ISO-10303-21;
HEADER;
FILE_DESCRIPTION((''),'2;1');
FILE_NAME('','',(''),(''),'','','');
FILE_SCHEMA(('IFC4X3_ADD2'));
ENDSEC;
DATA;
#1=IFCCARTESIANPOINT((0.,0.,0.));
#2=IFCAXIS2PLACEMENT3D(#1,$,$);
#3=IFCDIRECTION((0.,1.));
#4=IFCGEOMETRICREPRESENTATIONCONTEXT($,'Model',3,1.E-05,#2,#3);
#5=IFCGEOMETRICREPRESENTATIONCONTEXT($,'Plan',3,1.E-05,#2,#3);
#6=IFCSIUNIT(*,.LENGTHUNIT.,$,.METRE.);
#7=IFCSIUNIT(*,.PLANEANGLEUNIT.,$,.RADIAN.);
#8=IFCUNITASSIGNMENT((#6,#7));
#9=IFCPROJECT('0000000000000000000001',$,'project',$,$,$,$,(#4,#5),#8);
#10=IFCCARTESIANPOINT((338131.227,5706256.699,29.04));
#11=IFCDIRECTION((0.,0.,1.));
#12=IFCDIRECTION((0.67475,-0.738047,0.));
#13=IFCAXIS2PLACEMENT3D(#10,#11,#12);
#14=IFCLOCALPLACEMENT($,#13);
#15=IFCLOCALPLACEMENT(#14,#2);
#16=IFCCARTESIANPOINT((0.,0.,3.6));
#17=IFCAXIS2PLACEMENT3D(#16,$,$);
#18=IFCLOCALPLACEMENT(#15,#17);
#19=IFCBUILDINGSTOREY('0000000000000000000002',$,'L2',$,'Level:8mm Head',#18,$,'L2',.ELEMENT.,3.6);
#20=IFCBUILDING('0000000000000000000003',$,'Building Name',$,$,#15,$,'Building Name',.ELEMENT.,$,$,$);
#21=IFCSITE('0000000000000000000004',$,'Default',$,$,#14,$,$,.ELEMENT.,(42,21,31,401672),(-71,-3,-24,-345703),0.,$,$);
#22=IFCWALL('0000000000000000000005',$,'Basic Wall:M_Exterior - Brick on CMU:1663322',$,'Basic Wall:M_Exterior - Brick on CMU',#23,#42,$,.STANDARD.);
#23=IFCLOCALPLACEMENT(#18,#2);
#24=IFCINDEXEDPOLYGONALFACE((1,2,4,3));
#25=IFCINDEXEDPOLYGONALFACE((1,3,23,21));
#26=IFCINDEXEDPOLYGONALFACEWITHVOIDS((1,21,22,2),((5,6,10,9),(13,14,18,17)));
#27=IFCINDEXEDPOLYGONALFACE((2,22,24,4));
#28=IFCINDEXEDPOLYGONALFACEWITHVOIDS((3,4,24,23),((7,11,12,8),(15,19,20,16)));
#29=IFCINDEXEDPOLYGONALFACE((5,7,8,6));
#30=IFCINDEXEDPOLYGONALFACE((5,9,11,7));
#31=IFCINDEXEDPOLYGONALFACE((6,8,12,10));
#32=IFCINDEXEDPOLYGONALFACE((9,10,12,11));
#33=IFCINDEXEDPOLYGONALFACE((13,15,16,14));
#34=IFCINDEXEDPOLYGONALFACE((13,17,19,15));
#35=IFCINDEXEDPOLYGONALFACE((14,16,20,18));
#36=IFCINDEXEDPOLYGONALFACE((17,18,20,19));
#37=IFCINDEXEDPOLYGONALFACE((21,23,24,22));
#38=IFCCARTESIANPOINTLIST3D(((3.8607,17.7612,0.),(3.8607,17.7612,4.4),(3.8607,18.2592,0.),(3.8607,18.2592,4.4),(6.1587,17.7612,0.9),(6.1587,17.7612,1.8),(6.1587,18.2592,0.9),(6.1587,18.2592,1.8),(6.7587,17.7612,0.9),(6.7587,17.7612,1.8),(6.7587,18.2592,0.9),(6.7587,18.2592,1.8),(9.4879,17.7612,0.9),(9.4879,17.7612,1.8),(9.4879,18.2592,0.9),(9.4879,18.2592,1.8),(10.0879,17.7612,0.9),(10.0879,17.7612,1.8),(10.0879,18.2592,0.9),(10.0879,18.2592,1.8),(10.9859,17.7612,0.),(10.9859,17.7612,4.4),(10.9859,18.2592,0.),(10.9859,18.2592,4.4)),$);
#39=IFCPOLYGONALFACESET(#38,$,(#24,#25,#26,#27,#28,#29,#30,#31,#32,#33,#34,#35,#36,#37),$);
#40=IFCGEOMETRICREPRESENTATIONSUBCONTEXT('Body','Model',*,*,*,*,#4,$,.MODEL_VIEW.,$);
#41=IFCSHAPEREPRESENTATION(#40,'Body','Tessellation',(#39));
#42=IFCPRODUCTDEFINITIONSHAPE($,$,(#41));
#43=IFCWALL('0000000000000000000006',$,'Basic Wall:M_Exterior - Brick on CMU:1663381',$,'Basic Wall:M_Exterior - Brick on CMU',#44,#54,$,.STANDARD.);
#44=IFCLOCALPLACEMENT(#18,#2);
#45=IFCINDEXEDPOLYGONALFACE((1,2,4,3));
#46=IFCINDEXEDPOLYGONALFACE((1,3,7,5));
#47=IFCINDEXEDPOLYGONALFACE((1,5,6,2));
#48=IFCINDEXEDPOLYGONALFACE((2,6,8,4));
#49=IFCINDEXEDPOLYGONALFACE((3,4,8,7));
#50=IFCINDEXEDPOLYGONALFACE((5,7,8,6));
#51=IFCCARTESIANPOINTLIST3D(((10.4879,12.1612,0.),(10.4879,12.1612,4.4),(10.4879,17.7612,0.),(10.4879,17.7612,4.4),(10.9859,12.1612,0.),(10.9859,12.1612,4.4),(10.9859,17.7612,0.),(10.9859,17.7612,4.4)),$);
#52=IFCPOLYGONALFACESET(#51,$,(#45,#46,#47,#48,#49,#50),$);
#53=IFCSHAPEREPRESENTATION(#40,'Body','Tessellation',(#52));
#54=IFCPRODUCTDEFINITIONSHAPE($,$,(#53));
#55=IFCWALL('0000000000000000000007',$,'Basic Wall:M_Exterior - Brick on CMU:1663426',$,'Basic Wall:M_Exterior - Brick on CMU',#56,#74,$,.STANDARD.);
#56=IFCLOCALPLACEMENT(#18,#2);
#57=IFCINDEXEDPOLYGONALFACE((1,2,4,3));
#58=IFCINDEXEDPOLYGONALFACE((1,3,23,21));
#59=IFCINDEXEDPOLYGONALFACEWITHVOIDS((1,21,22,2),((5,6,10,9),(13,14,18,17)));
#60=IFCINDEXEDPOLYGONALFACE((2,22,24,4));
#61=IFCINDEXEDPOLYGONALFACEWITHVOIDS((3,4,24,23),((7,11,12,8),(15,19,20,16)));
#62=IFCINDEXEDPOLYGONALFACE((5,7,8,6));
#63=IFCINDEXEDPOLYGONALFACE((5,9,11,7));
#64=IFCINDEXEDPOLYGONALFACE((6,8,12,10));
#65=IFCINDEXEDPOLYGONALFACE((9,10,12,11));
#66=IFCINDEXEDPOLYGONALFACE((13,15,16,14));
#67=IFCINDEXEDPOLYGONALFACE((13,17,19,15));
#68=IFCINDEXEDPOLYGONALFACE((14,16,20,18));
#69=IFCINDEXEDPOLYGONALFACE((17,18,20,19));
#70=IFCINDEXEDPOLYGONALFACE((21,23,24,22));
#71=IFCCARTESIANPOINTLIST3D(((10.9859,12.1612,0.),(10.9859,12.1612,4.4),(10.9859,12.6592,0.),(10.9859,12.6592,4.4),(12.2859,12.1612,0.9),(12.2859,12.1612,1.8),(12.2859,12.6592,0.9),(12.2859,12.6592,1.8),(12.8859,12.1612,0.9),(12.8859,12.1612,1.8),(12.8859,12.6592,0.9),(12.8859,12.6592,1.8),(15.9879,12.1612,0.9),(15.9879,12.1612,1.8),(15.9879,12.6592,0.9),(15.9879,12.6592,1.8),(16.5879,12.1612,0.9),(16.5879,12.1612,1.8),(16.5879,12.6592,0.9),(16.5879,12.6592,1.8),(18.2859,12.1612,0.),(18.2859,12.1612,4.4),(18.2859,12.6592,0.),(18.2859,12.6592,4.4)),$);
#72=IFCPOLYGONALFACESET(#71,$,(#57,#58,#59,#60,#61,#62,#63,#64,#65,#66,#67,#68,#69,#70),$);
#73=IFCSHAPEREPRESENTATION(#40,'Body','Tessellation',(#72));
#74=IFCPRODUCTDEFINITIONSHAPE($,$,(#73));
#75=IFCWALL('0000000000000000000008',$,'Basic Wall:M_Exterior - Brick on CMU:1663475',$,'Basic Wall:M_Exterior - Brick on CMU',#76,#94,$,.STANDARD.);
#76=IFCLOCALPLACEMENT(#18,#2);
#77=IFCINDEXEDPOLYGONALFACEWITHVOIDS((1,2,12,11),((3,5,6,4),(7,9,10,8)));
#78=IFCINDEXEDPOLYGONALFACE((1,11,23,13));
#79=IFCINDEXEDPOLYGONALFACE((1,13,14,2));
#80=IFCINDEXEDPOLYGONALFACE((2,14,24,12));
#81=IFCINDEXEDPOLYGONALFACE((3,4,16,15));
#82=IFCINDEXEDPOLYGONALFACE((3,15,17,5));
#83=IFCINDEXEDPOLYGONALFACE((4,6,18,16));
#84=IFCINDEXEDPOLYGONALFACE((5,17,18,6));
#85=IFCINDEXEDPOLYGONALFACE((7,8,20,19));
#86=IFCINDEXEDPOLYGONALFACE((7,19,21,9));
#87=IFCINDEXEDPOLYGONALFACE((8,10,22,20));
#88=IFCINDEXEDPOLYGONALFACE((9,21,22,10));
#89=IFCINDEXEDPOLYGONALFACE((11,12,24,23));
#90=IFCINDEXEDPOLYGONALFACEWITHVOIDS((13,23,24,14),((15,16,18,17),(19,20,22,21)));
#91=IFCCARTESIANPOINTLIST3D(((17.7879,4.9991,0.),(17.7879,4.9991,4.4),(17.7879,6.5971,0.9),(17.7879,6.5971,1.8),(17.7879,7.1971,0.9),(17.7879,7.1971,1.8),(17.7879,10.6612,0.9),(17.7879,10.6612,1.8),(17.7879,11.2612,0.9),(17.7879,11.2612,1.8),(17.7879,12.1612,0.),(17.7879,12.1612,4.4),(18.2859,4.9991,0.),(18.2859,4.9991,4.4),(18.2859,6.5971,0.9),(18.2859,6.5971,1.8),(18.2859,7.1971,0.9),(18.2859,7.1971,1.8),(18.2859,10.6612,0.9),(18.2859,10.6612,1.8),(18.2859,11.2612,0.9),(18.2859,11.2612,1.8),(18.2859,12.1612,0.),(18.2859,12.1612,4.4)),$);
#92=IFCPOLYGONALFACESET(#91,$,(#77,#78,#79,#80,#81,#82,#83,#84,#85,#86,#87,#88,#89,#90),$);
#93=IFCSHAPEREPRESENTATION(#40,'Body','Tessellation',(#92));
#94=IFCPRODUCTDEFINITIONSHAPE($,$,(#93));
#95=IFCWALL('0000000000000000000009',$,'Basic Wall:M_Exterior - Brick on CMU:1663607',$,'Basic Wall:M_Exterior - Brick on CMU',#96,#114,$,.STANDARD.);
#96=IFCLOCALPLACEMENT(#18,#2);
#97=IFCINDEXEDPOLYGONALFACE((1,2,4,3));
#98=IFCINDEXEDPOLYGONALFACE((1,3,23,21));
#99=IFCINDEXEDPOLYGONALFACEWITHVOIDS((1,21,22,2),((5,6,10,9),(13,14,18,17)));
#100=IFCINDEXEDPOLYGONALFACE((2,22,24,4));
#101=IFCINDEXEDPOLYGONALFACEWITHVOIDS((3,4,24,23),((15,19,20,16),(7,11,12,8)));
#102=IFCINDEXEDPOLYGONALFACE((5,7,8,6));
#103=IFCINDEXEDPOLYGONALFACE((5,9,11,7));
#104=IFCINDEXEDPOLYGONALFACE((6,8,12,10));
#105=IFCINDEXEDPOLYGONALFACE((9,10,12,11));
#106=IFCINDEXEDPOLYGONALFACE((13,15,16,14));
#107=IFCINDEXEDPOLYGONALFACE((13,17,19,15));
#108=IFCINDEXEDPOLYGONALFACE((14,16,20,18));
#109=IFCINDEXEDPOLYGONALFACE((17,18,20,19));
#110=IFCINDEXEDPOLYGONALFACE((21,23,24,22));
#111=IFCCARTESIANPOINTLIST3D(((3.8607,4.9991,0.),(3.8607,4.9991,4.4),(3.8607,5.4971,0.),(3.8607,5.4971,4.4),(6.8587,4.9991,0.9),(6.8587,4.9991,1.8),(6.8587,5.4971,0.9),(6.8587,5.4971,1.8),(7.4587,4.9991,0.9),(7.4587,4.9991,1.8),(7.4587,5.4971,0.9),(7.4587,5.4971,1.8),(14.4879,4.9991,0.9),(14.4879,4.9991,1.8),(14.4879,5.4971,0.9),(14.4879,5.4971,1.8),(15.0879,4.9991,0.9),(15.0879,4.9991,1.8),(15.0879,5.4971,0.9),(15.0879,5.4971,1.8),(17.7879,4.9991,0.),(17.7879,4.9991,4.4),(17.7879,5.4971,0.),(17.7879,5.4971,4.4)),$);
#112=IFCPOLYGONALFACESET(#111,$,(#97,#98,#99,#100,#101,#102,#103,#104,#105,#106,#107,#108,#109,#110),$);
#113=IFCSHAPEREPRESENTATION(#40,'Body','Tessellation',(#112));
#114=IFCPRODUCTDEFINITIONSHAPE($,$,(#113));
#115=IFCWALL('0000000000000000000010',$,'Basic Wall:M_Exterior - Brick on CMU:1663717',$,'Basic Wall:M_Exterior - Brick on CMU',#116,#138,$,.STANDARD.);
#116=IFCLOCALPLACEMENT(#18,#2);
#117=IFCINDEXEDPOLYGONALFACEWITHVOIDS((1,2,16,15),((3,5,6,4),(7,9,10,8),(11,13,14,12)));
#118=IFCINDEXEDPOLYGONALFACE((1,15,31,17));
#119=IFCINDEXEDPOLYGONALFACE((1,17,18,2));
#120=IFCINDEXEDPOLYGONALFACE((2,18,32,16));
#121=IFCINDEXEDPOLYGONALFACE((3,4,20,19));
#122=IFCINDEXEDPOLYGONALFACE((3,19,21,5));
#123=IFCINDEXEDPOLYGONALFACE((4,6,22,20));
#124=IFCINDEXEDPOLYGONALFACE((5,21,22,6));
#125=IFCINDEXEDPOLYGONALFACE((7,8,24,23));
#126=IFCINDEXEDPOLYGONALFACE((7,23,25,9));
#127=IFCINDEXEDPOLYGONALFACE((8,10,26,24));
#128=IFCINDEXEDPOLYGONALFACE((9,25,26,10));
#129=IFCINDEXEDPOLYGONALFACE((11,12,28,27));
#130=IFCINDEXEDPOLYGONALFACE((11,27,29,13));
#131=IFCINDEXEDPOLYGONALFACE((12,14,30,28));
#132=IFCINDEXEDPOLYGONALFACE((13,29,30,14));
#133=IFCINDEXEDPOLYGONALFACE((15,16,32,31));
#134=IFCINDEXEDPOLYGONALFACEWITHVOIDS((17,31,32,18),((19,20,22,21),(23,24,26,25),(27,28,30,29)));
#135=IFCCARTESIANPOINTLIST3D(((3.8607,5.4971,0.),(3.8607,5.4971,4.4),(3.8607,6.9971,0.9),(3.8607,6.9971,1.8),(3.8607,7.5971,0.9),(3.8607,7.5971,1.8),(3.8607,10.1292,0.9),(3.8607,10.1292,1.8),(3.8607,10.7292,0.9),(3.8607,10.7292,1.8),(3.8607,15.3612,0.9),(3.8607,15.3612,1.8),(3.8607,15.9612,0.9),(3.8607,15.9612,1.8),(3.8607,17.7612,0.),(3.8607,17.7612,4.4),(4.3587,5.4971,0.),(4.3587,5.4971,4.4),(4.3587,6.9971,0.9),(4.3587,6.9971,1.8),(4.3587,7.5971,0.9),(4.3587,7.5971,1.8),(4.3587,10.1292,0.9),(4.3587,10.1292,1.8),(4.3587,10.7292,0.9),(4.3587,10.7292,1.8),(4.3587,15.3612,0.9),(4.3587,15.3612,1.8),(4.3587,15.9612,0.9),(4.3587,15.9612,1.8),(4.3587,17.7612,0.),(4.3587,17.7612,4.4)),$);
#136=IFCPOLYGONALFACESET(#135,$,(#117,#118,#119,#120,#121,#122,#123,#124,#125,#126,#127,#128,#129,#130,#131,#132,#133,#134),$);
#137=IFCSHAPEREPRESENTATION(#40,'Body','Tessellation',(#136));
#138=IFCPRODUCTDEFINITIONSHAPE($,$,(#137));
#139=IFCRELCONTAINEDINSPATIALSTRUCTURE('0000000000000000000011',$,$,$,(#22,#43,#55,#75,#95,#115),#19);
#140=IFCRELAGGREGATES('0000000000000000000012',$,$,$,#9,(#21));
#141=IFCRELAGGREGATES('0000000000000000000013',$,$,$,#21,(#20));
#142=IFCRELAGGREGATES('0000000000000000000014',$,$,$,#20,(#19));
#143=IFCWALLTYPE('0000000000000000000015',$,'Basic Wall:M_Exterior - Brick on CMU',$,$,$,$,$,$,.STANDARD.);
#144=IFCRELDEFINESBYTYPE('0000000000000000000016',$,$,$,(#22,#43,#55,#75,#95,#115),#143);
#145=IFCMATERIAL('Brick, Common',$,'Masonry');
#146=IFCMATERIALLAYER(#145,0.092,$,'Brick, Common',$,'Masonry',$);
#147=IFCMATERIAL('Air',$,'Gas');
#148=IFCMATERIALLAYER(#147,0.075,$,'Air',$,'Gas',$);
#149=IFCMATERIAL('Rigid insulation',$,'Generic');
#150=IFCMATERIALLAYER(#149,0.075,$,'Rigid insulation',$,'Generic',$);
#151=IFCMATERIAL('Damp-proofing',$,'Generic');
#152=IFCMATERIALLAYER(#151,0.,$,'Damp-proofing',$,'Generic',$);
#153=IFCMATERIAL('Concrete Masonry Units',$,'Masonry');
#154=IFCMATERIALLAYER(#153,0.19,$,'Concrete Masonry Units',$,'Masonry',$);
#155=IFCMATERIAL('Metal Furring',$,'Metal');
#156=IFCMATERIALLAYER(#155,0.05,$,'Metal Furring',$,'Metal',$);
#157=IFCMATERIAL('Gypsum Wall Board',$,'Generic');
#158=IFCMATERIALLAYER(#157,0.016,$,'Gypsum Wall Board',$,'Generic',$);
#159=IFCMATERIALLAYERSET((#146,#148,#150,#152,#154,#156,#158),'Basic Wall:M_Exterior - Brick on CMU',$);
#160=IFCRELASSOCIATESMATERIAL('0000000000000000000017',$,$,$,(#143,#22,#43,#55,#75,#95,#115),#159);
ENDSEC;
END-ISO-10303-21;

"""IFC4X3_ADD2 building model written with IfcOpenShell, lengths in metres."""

from ifc_helpers import new_model, si_unit, direction, frame, frame_2d, origin, place, context, subcontext, project, spatial, rectangle, extrude, material, layer, layer_set, type_object, element, save


model = new_model("IFC4X3_ADD2")

# Units and contexts
model_context = context("Model", 3, precision=1e-05, world=origin(), true_north=direction((0.0, 1.0)))
plan_context = context("Plan", 3, precision=1e-05, world=origin(), true_north=direction((0.0, 1.0)))
body_context = subcontext(model_context, "Body", "Model", "MODEL_VIEW")
ifc_project = project(units=[si_unit("LENGTHUNIT", "METRE"), si_unit("PLANEANGLEUNIT", "RADIAN")], contexts=[model_context, plan_context])

# Site, building, storey
site_placement = place(None, frame((338131.227, 5706256.699, 29.04), z_axis=(0.0, 0.0, 1.0), x_axis=(0.67475, -0.738047, 0.0)))
site = spatial("IfcSite", under=ifc_project, at=site_placement, Name="Default", CompositionType="ELEMENT", RefLatitude=(42, 21, 31, 401672), RefLongitude=(-71, -3, -24, -345703), RefElevation=0.0)
building_placement = place(site_placement, origin())
building = spatial("IfcBuilding", under=site, at=building_placement, Name="Building Name", LongName="Building Name", CompositionType="ELEMENT")
storey_placement = place(building_placement, frame((0.0, 0.0, 3.6)))
storey = spatial("IfcBuildingStorey", under=building, at=storey_placement, Name="L2", ObjectType="Level:8mm Head", LongName="L2", CompositionType="ELEMENT", Elevation=3.6)

# Wall, openings
ifc_material_1 = material(Name="Brick, Common", Category="Masonry")
ifc_layer_1 = layer(ifc_material_1, 0.092, Name="Brick, Common", Category="Masonry")
ifc_material_2 = material(Name="Air", Category="Gas")
ifc_layer_2 = layer(ifc_material_2, 0.075, Name="Air", Category="Gas")
ifc_material_3 = material(Name="Rigid insulation", Category="Generic")
ifc_layer_3 = layer(ifc_material_3, 0.075, Name="Rigid insulation", Category="Generic")
ifc_material_4 = material(Name="Damp-proofing", Category="Generic")
ifc_layer_4 = layer(ifc_material_4, 0.0, Name="Damp-proofing", Category="Generic")
ifc_material_5 = material(Name="Concrete Masonry Units", Category="Masonry")
ifc_layer_5 = layer(ifc_material_5, 0.19, Name="Concrete Masonry Units", Category="Masonry")
ifc_material_6 = material(Name="Metal Furring", Category="Metal")
ifc_layer_6 = layer(ifc_material_6, 0.05, Name="Metal Furring", Category="Metal")
ifc_material_7 = material(Name="Gypsum Wall Board", Category="Generic")
ifc_layer_7 = layer(ifc_material_7, 0.016, Name="Gypsum Wall Board", Category="Generic")
ifc_layer_set = layer_set([ifc_layer_1, ifc_layer_2, ifc_layer_3, ifc_layer_4, ifc_layer_5, ifc_layer_6, ifc_layer_7], Name="Basic Wall:M_Exterior - Brick on CMU")
wall_type = type_object("IfcWallType", Name="Basic Wall:M_Exterior - Brick on CMU", PredefinedType="STANDARD", material=ifc_layer_set)
wall_1_placement = place(storey_placement, frame((3.8607, 18.0102, 0.0)))
wall_1 = element("IfcWall", 1, at=wall_1_placement, inside=storey, type_object=wall_type, material=ifc_layer_set, Name="Basic Wall:M_Exterior - Brick on CMU:1663322", ObjectType="Basic Wall:M_Exterior - Brick on CMU", PredefinedType="STANDARD", context=body_context, shape_type="SweptSolid", body=[
    extrude(rectangle(XDim=7.1251, YDim=0.498, at=frame_2d((3.5626, 0.0), x_axis=(-1.0, 0.0))), origin(), (0.0, 0.0, 1.0), 4.4),
])
opening_1_placement = place(wall_1_placement, frame((-3.8607, -18.0102, 0.9)))
element("IfcOpeningElement", 2, at=opening_1_placement, cuts=wall_1, PredefinedType="OPENING", context=body_context, shape_type="SweptSolid", body=[
    extrude(rectangle(XDim=0.9, YDim=0.6, at=frame_2d((0.0, 0.0), x_axis=(1.0, 0.0))), frame((9.7879, 16.2372, 0.45), z_axis=(0.0, 1.0, 0.0), x_axis=(0.0, 0.0, -1.0)), (0.0, 0.0, 1.0), 3.048),
])
opening_2_placement = place(wall_1_placement, frame((-3.8607, -18.0102, 0.9)))
element("IfcOpeningElement", 3, at=opening_2_placement, cuts=wall_1, PredefinedType="OPENING", context=body_context, shape_type="SweptSolid", body=[
    extrude(rectangle(XDim=0.9, YDim=0.6, at=frame_2d((0.0, 0.0), x_axis=(1.0, 0.0))), frame((6.4587, 16.2372, 0.45), z_axis=(0.0, 1.0, 0.0), x_axis=(0.0, 0.0, -1.0)), (0.0, 0.0, 1.0), 3.048),
])

# Wall
wall_2_placement = place(storey_placement, frame((10.7369, 17.7612, 0.0), z_axis=(0.0, 0.0, 1.0), x_axis=(0.0, -1.0, 0.0)))
element("IfcWall", 4, at=wall_2_placement, inside=storey, type_object=wall_type, material=ifc_layer_set, Name="Basic Wall:M_Exterior - Brick on CMU:1663381", ObjectType="Basic Wall:M_Exterior - Brick on CMU", PredefinedType="STANDARD", context=body_context, shape_type="SweptSolid", body=[
    extrude(rectangle(XDim=5.6, YDim=0.498, at=frame_2d((2.8, 0.0), x_axis=(-1.0, 0.0))), origin(), (0.0, 0.0, 1.0), 4.4),
])

# Walls, openings
wall_3_placement = place(storey_placement, frame((10.9859, 12.4102, 0.0)))
wall_3 = element("IfcWall", 5, at=wall_3_placement, inside=storey, type_object=wall_type, material=ifc_layer_set, Name="Basic Wall:M_Exterior - Brick on CMU:1663426", ObjectType="Basic Wall:M_Exterior - Brick on CMU", PredefinedType="STANDARD", context=body_context, shape_type="SweptSolid", body=[
    extrude(rectangle(XDim=7.3, YDim=0.498, at=frame_2d((3.65, 0.0), x_axis=(-1.0, 0.0))), origin(), (0.0, 0.0, 1.0), 4.4),
])
opening_3_placement = place(wall_3_placement, frame((-10.9859, -12.4102, 0.9)))
element("IfcOpeningElement", 6, at=opening_3_placement, cuts=wall_3, PredefinedType="OPENING", context=body_context, shape_type="SweptSolid", body=[
    extrude(rectangle(XDim=0.9, YDim=0.6, at=frame_2d((0.0, 0.0), x_axis=(1.0, 0.0))), frame((16.2879, 10.6372, 0.45), z_axis=(0.0, 1.0, 0.0), x_axis=(0.0, 0.0, -1.0)), (0.0, 0.0, 1.0), 3.048),
])
opening_4_placement = place(wall_3_placement, frame((-10.9859, -12.4102, 0.9)))
element("IfcOpeningElement", 7, at=opening_4_placement, cuts=wall_3, PredefinedType="OPENING", context=body_context, shape_type="SweptSolid", body=[
    extrude(rectangle(XDim=0.9, YDim=0.6, at=frame_2d((0.0, 0.0), x_axis=(1.0, 0.0))), frame((12.5859, 10.6372, 0.45), z_axis=(0.0, 1.0, 0.0), x_axis=(0.0, 0.0, -1.0)), (0.0, 0.0, 1.0), 3.048),
])
wall_4_placement = place(storey_placement, frame((18.0369, 12.1612, 0.0), z_axis=(0.0, 0.0, 1.0), x_axis=(0.0, -1.0, 0.0)))
wall_4 = element("IfcWall", 8, at=wall_4_placement, inside=storey, type_object=wall_type, material=ifc_layer_set, Name="Basic Wall:M_Exterior - Brick on CMU:1663475", ObjectType="Basic Wall:M_Exterior - Brick on CMU", PredefinedType="STANDARD", context=body_context, shape_type="SweptSolid", body=[
    extrude(rectangle(XDim=7.1621, YDim=0.498, at=frame_2d((3.581, 0.0), x_axis=(-1.0, 0.0))), origin(), (0.0, 0.0, 1.0), 4.4),
])
opening_5_placement = place(wall_4_placement, frame((12.1612, -18.0369, 0.9)))
element("IfcOpeningElement", 9, at=opening_5_placement, cuts=wall_4, PredefinedType="OPENING", context=body_context, shape_type="SweptSolid", body=[
    extrude(rectangle(XDim=0.9, YDim=0.6, at=frame_2d((0.0, 0.0), x_axis=(1.0, 0.0))), frame((-6.8971, 16.2639, 0.45), z_axis=(0.0, 1.0, 0.0), x_axis=(0.0, 0.0, -1.0)), (0.0, 0.0, 1.0), 3.048),
])
opening_6_placement = place(wall_4_placement, frame((12.1612, -18.0369, 0.9)))
element("IfcOpeningElement", 10, at=opening_6_placement, cuts=wall_4, PredefinedType="OPENING", context=body_context, shape_type="SweptSolid", body=[
    extrude(rectangle(XDim=0.9, YDim=0.6, at=frame_2d((0.0, 0.0), x_axis=(1.0, 0.0))), frame((-10.9612, 16.2639, 0.45), z_axis=(0.0, 1.0, 0.0), x_axis=(0.0, 0.0, -1.0)), (0.0, 0.0, 1.0), 3.048),
])
wall_5_placement = place(storey_placement, frame((17.7879, 5.2481, 0.0), z_axis=(0.0, 0.0, 1.0), x_axis=(-1.0, 0.0, 0.0)))
wall_5 = element("IfcWall", 11, at=wall_5_placement, inside=storey, type_object=wall_type, material=ifc_layer_set, Name="Basic Wall:M_Exterior - Brick on CMU:1663607", ObjectType="Basic Wall:M_Exterior - Brick on CMU", PredefinedType="STANDARD", context=body_context, shape_type="SweptSolid", body=[
    extrude(rectangle(XDim=13.9271, YDim=0.498, at=frame_2d((6.9636, 0.0), x_axis=(-1.0, 0.0))), origin(), (0.0, 0.0, 1.0), 4.4),
])
opening_7_placement = place(wall_5_placement, frame((17.7879, 5.2481, 0.9)))
element("IfcOpeningElement", 12, at=opening_7_placement, cuts=wall_5, PredefinedType="OPENING", context=body_context, shape_type="SweptSolid", body=[
    extrude(rectangle(XDim=0.9, YDim=0.6, at=frame_2d((0.0, 0.0), x_axis=(1.0, 0.0))), frame((-7.1587, -7.0211, 0.45), z_axis=(0.0, 1.0, 0.0), x_axis=(0.0, 0.0, -1.0)), (0.0, 0.0, 1.0), 3.048),
])
opening_8_placement = place(wall_5_placement, frame((17.7879, 5.2481, 0.9)))
element("IfcOpeningElement", 13, at=opening_8_placement, cuts=wall_5, PredefinedType="OPENING", context=body_context, shape_type="SweptSolid", body=[
    extrude(rectangle(XDim=0.9, YDim=0.6, at=frame_2d((0.0, 0.0), x_axis=(1.0, 0.0))), frame((-14.7879, -7.0211, 0.45), z_axis=(0.0, 1.0, 0.0), x_axis=(0.0, 0.0, -1.0)), (0.0, 0.0, 1.0), 3.048),
])
wall_6_placement = place(storey_placement, frame((4.1097, 5.4971, 0.0), z_axis=(0.0, 0.0, 1.0), x_axis=(0.0, 1.0, 0.0)))
wall_6 = element("IfcWall", 14, at=wall_6_placement, inside=storey, type_object=wall_type, material=ifc_layer_set, Name="Basic Wall:M_Exterior - Brick on CMU:1663717", ObjectType="Basic Wall:M_Exterior - Brick on CMU", PredefinedType="STANDARD", context=body_context, shape_type="SweptSolid", body=[
    extrude(rectangle(XDim=12.2641, YDim=0.498, at=frame_2d((6.132, 0.0), x_axis=(-1.0, 0.0))), origin(), (0.0, 0.0, 1.0), 4.4),
])
opening_9_placement = place(wall_6_placement, frame((-5.4971, 4.1097, 0.9)))
element("IfcOpeningElement", 15, at=opening_9_placement, cuts=wall_6, PredefinedType="OPENING", context=body_context, shape_type="SweptSolid", body=[
    extrude(rectangle(XDim=0.9, YDim=0.6, at=frame_2d((0.0, 0.0), x_axis=(1.0, 0.0))), frame((15.6612, -5.8827, 0.45), z_axis=(0.0, 1.0, 0.0), x_axis=(0.0, 0.0, -1.0)), (0.0, 0.0, 1.0), 3.048),
])
opening_10_placement = place(wall_6_placement, frame((-5.4971, 4.1097, 0.9)))
element("IfcOpeningElement", 16, at=opening_10_placement, cuts=wall_6, PredefinedType="OPENING", context=body_context, shape_type="SweptSolid", body=[
    extrude(rectangle(XDim=0.9, YDim=0.6, at=frame_2d((0.0, 0.0), x_axis=(1.0, 0.0))), frame((10.4292, -5.8827, 0.45), z_axis=(0.0, 1.0, 0.0), x_axis=(0.0, 0.0, -1.0)), (0.0, 0.0, 1.0), 3.048),
])
opening_11_placement = place(wall_6_placement, frame((-5.4971, 4.1097, 0.9)))
element("IfcOpeningElement", 17, at=opening_11_placement, cuts=wall_6, PredefinedType="OPENING", context=body_context, shape_type="SweptSolid", body=[
    extrude(rectangle(XDim=0.9, YDim=0.6, at=frame_2d((0.0, 0.0), x_axis=(1.0, 0.0))), frame((7.2971, -5.8827, 0.45), z_axis=(0.0, 1.0, 0.0), x_axis=(0.0, 0.0, -1.0)), (0.0, 0.0, 1.0), 3.048),
])

save(model, "model.ifc")
